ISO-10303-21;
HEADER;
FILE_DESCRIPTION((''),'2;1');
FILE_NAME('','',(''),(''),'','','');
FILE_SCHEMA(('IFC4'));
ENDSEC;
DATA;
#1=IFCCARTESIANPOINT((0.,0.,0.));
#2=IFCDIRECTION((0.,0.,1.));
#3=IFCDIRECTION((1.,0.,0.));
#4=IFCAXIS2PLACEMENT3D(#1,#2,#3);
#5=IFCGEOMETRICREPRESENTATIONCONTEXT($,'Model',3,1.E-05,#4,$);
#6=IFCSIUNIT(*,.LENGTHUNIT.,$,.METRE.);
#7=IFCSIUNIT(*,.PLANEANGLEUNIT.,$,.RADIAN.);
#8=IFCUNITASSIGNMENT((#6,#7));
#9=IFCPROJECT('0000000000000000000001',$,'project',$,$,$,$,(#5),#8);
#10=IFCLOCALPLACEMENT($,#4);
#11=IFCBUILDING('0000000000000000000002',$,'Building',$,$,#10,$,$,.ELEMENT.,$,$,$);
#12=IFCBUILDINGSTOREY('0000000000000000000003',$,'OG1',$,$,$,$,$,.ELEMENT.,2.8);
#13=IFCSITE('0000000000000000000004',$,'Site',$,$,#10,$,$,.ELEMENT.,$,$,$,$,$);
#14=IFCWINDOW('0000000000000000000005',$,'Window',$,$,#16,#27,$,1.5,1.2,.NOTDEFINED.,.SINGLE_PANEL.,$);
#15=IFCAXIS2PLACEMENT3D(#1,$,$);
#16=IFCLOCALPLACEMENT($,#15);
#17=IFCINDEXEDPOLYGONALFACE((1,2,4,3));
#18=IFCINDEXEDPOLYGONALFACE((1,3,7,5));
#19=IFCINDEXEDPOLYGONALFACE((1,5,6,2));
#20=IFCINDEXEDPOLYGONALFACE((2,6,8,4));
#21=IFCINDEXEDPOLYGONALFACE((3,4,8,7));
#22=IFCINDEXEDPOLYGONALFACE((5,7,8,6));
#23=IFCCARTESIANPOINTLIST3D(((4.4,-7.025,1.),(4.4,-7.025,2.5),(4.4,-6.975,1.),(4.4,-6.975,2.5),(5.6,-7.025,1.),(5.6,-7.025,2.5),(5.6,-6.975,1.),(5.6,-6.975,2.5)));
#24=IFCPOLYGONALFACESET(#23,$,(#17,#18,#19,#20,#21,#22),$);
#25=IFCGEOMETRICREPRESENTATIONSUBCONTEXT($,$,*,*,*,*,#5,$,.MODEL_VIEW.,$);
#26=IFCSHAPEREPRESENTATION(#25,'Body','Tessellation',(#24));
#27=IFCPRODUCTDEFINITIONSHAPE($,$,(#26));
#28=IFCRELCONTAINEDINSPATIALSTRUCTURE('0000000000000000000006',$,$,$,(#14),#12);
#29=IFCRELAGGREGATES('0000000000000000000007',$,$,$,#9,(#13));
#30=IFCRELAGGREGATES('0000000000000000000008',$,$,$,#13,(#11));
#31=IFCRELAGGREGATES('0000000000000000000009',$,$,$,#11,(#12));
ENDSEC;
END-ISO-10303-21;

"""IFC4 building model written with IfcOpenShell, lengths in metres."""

from ifc_helpers import new_model, si_unit, frame, origin, origin_with_axes, origin_2d, place, context, subcontext, project, spatial, rectangle, extrude, element, save


model = new_model("IFC4")

# Units and contexts
model_context = context("Model", 3, precision=1e-05, world=origin_with_axes())
sub_context = subcontext(model_context, None, None, "MODEL_VIEW")
ifc_project = project(units=[si_unit("LENGTHUNIT", "METRE"), si_unit("PLANEANGLEUNIT", "RADIAN")], contexts=[model_context])

# Site, building, storey
placement_1 = place(None, origin_with_axes())
site = spatial("IfcSite", under=ifc_project, at=placement_1, Name="Site", CompositionType="ELEMENT")
building = spatial("IfcBuilding", under=site, at=placement_1, Name="Building", CompositionType="ELEMENT")
storey = spatial("IfcBuildingStorey", under=building, Name="OG1", CompositionType="ELEMENT", Elevation=2.8)

# Window
placement_2 = place(None, origin_with_axes())
window_placement = place(placement_2, frame((5.0, -7.0, 1.0)))
element("IfcWindow", 1, at=window_placement, inside=storey, Name="Window", OverallHeight=1.5, OverallWidth=1.2, PartitioningType="SINGLE_PANEL", PredefinedType="NOTDEFINED", context=sub_context, shape_type="SweptSolid", body=[
    extrude(rectangle(XDim=1.2, YDim=0.05, at=origin_2d()), origin(), (0.0, 0.0, 1.0), 1.5),
])

save(model, "model.ifc")
